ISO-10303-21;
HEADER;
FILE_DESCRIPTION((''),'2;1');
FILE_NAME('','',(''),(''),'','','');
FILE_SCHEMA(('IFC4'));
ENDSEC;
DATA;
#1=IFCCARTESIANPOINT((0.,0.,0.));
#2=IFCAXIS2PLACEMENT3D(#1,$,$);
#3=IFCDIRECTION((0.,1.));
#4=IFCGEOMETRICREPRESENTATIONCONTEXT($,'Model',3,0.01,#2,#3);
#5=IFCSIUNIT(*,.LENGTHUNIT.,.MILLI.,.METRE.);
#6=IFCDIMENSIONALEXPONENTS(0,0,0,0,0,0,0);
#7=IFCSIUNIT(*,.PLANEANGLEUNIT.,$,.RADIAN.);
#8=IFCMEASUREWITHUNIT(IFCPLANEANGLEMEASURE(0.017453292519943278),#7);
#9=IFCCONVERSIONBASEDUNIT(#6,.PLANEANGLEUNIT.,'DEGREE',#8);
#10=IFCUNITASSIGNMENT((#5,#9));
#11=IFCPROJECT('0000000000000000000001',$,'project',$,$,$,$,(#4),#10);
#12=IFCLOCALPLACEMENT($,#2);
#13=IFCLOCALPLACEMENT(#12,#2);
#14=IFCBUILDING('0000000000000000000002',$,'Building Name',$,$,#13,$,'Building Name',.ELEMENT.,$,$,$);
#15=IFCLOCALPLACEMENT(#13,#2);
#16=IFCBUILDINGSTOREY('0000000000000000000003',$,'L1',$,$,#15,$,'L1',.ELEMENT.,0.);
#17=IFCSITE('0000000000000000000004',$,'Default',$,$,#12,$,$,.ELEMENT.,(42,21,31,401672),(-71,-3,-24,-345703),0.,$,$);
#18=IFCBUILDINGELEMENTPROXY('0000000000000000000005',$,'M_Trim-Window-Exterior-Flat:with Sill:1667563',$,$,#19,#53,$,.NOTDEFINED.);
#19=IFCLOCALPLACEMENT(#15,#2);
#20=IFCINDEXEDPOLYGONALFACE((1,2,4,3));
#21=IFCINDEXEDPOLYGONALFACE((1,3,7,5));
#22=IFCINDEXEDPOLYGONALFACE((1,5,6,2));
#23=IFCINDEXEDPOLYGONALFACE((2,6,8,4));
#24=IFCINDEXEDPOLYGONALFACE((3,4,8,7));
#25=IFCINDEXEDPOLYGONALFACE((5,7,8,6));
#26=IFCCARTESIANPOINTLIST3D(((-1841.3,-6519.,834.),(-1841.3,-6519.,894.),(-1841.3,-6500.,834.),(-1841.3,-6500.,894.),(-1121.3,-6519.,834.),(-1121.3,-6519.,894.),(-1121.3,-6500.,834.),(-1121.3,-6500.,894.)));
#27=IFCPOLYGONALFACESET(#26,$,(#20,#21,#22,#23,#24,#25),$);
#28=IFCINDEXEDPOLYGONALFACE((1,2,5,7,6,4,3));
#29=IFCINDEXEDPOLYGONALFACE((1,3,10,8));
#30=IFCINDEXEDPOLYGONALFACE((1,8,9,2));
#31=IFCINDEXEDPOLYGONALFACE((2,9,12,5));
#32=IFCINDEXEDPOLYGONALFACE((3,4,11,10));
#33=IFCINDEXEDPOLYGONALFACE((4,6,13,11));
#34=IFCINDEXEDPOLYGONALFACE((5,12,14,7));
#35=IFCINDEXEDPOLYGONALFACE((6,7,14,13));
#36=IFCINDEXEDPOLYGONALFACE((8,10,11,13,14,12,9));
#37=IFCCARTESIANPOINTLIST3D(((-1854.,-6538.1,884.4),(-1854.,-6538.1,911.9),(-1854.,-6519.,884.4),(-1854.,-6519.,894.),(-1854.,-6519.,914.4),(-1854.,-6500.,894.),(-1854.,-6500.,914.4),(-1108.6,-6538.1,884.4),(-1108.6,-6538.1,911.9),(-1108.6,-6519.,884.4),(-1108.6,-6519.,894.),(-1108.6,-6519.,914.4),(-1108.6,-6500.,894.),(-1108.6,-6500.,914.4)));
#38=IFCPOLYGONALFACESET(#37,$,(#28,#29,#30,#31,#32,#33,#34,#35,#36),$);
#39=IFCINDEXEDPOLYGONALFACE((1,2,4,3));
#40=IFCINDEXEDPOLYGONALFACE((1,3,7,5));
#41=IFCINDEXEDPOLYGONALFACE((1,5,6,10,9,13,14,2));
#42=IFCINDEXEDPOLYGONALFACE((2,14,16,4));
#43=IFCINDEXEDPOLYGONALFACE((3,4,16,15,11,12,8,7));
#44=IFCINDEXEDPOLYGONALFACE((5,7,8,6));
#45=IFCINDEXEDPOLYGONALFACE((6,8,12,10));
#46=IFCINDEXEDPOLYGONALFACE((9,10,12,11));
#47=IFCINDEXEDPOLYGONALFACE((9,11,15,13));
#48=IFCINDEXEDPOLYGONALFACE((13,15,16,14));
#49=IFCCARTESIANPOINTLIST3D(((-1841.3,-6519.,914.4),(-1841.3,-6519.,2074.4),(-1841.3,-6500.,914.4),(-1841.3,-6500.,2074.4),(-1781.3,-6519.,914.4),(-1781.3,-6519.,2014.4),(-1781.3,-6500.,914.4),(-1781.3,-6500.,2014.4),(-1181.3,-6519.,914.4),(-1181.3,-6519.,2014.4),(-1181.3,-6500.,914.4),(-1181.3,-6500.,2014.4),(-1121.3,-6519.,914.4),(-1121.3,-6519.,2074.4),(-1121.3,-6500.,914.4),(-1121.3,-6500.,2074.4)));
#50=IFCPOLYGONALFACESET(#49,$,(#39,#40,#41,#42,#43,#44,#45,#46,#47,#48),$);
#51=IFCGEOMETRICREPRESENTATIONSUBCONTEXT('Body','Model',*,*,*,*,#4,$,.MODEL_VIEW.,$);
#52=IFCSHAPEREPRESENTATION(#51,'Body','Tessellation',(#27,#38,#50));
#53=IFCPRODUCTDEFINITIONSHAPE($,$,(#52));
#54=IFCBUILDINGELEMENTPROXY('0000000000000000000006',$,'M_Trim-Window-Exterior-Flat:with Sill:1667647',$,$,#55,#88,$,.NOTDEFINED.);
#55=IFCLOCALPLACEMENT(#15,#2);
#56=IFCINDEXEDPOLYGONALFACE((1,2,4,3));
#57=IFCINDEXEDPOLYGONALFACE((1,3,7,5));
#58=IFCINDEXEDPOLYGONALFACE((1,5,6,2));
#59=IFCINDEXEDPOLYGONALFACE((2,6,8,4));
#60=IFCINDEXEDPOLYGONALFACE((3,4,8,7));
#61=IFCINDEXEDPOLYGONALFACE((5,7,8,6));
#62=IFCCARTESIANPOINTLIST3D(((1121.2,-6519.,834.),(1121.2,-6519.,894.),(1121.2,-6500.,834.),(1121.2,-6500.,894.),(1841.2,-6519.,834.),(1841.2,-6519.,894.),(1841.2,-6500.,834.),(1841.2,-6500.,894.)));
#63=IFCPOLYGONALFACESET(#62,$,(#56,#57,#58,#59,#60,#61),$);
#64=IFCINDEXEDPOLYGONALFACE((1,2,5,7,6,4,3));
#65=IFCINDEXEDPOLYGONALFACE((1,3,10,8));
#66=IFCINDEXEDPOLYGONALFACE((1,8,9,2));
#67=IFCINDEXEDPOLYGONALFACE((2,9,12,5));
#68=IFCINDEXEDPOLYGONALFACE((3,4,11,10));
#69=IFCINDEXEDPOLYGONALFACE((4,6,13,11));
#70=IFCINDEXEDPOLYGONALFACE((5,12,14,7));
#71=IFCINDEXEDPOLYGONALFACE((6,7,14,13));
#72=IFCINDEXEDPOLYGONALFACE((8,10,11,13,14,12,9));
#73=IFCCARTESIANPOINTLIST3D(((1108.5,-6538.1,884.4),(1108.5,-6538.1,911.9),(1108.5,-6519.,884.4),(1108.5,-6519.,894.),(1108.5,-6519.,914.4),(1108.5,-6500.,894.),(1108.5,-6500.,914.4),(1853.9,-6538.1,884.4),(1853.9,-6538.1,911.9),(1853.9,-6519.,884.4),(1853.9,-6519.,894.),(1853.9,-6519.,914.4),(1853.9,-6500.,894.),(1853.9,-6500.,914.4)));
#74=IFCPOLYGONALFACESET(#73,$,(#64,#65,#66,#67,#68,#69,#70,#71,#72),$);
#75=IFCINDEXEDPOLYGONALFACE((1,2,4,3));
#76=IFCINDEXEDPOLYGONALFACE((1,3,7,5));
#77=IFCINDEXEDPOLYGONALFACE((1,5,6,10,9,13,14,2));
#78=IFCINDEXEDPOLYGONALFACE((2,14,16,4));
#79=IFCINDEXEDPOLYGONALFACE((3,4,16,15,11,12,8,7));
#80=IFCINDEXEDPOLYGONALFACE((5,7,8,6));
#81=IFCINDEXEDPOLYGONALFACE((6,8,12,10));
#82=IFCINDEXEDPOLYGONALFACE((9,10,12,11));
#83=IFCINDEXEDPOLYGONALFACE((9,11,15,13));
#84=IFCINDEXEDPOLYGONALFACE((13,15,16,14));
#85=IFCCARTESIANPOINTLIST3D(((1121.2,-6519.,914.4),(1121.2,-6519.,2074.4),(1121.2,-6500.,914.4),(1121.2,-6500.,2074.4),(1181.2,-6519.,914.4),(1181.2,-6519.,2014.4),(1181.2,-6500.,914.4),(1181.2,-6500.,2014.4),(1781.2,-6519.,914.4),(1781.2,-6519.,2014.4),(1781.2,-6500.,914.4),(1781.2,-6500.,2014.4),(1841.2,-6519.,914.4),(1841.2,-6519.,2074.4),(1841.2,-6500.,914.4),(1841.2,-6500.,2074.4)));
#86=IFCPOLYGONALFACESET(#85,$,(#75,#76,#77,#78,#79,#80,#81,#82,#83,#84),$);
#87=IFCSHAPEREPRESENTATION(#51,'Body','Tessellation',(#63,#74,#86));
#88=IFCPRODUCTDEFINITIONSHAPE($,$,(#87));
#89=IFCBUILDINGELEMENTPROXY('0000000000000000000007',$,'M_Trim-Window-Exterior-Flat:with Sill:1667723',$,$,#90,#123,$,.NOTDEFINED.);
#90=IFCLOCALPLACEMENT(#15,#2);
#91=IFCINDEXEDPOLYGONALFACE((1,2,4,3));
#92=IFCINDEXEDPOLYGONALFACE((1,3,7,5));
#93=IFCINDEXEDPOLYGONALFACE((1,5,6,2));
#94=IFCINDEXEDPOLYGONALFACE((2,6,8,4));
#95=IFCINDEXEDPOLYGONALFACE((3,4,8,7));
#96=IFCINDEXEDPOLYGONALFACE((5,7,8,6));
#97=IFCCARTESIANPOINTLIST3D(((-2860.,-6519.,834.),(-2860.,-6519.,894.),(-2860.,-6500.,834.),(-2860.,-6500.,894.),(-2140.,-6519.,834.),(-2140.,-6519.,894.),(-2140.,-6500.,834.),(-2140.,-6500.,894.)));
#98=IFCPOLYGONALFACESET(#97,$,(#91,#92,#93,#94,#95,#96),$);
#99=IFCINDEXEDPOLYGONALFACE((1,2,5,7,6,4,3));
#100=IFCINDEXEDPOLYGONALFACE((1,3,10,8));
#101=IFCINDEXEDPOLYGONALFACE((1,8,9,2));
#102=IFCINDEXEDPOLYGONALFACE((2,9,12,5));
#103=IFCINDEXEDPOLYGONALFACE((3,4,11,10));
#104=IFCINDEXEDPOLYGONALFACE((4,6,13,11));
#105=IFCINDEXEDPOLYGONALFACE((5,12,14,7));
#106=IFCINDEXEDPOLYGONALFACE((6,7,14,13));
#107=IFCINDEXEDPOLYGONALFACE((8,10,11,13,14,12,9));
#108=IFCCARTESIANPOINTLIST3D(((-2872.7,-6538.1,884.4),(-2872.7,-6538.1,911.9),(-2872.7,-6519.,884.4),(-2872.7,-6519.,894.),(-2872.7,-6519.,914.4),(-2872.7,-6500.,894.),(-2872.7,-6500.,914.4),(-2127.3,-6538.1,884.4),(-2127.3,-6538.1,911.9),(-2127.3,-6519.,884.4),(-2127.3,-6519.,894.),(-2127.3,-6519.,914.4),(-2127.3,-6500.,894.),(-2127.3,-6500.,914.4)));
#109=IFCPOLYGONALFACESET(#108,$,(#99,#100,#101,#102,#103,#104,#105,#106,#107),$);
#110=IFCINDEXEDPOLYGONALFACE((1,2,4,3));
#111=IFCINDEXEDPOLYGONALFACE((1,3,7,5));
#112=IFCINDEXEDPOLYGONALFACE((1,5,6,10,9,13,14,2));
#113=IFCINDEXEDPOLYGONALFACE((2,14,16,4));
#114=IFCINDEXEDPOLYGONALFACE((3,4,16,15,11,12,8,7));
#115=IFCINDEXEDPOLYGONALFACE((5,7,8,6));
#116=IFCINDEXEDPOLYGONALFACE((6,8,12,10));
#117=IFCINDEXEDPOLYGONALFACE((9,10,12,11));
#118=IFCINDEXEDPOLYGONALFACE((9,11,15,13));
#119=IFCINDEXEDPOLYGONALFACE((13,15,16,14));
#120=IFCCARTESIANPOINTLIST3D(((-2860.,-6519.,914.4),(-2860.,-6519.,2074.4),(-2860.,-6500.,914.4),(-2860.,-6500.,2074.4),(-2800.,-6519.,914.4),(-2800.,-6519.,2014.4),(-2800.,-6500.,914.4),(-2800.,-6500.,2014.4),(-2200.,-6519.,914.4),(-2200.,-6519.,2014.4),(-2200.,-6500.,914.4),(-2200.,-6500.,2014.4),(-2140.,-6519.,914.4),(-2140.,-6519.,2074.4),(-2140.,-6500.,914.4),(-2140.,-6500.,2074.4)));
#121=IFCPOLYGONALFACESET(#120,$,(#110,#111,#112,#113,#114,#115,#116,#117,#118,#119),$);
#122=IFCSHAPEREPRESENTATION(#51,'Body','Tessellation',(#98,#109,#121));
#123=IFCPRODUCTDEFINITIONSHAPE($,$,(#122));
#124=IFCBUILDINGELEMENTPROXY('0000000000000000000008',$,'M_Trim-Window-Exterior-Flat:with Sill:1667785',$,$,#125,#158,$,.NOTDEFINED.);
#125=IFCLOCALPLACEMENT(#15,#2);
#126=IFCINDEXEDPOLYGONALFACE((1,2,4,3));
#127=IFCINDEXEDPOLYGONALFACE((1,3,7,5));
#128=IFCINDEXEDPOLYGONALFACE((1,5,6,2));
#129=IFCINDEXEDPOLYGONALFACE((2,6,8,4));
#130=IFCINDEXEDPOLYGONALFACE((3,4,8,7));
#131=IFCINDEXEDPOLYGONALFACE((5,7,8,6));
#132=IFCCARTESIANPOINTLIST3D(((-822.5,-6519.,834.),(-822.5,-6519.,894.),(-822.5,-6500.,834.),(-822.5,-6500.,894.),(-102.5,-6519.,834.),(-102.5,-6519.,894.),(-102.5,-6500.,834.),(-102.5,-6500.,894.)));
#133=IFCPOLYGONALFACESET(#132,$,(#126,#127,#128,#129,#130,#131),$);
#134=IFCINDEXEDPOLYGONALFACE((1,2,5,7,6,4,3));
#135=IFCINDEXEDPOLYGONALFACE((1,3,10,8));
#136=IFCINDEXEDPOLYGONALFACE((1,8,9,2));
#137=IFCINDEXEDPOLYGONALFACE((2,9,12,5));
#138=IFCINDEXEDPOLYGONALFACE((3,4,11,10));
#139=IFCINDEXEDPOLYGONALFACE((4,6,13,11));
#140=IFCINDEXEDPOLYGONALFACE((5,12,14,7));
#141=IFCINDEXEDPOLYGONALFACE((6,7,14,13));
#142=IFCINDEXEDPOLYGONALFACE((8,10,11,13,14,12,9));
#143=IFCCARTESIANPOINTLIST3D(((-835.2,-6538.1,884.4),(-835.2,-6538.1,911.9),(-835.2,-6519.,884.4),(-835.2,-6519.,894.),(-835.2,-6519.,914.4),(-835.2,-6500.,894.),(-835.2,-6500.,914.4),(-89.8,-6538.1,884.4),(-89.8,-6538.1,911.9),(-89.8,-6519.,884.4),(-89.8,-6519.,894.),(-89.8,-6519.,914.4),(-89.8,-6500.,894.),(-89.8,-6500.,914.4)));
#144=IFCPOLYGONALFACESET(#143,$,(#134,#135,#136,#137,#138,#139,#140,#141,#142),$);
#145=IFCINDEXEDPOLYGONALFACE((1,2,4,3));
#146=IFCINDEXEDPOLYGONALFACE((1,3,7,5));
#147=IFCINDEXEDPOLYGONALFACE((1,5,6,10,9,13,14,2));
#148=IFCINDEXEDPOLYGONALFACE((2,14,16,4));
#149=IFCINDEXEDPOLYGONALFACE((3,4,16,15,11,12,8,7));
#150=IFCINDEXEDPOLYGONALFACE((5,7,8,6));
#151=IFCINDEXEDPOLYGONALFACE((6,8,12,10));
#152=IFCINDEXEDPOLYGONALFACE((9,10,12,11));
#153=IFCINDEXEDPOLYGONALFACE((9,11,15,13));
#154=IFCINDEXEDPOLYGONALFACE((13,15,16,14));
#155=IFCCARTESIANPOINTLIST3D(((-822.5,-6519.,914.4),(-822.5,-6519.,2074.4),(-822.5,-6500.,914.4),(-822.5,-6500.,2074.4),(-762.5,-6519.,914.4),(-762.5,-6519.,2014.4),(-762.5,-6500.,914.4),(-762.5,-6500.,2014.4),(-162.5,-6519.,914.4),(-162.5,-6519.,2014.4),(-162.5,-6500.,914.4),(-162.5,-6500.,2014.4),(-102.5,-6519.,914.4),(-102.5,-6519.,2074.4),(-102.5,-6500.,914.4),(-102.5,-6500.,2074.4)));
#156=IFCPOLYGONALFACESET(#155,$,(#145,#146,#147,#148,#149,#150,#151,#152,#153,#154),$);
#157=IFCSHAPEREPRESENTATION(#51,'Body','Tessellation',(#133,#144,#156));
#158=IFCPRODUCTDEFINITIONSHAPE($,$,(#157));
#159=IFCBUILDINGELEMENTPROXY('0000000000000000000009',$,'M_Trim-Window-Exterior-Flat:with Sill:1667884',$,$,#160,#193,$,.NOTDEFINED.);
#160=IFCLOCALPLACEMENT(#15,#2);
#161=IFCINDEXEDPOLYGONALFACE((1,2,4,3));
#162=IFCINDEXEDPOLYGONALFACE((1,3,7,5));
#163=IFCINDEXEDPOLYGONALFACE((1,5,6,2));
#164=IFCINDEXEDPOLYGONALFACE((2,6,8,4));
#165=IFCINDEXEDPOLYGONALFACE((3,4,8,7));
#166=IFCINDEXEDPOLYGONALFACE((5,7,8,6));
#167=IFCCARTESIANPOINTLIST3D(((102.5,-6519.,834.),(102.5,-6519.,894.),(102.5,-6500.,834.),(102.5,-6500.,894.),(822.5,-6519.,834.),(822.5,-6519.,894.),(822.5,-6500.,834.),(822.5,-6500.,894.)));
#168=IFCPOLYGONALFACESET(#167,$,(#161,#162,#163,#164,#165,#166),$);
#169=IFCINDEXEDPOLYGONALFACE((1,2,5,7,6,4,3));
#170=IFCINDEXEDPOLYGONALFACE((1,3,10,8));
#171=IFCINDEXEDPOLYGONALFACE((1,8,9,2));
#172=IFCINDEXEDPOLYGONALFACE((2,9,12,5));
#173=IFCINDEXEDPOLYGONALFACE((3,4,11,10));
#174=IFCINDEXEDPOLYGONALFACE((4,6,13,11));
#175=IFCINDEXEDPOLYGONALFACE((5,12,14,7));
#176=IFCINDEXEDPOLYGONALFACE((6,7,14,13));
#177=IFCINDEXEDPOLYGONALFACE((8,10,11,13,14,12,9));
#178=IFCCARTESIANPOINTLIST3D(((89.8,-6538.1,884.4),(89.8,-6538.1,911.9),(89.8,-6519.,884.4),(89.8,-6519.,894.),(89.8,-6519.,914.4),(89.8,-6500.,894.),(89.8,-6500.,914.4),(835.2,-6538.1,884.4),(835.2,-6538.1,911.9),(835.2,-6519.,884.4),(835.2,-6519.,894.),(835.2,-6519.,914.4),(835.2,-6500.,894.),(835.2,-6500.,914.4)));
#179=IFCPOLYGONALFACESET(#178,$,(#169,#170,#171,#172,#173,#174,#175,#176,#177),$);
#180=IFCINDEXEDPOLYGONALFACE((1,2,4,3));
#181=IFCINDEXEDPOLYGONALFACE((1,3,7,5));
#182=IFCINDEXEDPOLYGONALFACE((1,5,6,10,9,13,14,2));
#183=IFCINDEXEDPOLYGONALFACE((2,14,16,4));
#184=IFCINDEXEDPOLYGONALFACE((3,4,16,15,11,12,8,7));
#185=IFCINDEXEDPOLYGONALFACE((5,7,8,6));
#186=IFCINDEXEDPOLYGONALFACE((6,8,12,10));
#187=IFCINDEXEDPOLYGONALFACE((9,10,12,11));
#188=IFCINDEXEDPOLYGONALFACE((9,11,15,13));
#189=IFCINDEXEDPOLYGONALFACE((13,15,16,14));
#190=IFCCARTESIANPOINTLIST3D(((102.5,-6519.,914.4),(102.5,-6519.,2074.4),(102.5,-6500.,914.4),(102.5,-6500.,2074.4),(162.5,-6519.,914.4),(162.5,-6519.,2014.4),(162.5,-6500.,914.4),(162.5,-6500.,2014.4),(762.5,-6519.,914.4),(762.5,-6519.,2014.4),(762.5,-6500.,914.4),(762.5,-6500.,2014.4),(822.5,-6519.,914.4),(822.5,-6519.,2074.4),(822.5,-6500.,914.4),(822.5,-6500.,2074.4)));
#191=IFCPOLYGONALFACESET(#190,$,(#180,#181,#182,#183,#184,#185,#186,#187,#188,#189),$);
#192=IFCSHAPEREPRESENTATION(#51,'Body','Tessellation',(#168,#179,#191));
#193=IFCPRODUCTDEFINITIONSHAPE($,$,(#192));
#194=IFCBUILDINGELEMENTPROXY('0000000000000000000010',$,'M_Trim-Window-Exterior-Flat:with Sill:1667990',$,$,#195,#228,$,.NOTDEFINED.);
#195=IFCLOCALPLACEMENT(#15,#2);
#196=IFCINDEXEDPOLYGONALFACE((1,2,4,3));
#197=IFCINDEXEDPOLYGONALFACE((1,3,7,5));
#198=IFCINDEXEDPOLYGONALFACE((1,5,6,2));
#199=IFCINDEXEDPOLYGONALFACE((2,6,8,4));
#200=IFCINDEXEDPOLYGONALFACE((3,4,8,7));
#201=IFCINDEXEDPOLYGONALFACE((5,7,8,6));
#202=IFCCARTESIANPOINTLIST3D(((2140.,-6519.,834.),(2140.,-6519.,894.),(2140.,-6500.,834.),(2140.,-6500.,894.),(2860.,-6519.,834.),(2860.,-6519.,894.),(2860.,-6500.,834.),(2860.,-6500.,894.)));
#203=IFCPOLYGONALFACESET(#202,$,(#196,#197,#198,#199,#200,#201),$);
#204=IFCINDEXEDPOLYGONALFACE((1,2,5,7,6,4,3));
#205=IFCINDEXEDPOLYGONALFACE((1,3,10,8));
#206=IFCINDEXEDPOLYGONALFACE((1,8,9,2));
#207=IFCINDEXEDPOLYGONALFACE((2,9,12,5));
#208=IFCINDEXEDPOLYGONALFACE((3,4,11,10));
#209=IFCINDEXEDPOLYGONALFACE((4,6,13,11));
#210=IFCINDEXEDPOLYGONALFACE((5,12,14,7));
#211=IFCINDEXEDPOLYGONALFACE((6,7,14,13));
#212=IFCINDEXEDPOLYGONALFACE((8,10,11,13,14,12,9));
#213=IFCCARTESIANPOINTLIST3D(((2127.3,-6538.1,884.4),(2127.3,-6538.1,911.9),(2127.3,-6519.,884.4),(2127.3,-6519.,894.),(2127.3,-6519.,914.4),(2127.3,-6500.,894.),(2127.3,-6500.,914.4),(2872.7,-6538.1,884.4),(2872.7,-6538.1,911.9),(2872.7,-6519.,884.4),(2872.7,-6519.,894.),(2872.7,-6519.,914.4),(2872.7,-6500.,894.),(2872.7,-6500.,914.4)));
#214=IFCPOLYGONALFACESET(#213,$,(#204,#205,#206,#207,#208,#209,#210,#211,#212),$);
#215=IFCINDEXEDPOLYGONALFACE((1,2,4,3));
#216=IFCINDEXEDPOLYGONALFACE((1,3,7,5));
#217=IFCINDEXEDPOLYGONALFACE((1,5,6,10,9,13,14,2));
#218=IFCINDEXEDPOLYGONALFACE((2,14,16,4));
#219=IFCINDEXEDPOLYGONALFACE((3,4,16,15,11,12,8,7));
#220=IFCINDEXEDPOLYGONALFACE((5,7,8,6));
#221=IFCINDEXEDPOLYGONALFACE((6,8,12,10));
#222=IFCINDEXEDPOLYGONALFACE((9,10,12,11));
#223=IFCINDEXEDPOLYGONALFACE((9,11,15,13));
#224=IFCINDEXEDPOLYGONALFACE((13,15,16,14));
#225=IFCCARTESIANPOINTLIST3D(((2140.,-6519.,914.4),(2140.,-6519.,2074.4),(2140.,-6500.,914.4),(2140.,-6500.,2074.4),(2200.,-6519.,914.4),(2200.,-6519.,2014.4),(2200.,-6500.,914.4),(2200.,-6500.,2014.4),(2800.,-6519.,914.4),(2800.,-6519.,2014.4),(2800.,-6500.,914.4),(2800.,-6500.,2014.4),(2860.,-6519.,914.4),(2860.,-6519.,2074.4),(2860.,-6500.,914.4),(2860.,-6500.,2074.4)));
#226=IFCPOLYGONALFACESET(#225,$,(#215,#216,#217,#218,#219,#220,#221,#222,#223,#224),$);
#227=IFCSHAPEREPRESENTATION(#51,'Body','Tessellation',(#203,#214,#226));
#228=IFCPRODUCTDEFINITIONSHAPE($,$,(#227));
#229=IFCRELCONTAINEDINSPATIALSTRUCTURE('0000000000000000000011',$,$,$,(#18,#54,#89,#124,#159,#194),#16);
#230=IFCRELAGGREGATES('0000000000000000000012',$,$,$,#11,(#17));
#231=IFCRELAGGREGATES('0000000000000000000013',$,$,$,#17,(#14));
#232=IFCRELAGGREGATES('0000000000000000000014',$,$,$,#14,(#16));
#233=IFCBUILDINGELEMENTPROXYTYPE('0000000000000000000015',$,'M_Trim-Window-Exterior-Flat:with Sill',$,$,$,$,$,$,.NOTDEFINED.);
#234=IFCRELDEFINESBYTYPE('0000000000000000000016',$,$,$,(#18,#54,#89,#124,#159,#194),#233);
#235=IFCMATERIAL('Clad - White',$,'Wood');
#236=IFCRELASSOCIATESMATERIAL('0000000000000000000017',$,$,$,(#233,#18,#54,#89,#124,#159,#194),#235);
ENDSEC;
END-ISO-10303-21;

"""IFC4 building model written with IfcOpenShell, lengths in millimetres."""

from ifc_helpers import new_model, entity, si_unit, converted_unit, direction, frame, origin, place, context, subcontext, project, spatial, indexed_curve, outline, extrude, source, transform, mapped, material, type_object, type_shapes, element, save


model = new_model("IFC4")

# Units and contexts
model_context = context("Model", 3, precision=0.01, world=origin(), true_north=direction((0.0, 1.0)))
body_context = subcontext(model_context, "Body", "Model", "MODEL_VIEW")
ifc_project = project(units=[si_unit("LENGTHUNIT", "METRE", prefix="MILLI"), converted_unit("PLANEANGLEUNIT", "DEGREE", entity("IfcPlaneAngleMeasure", 0.017453292519943278), si_unit("PLANEANGLEUNIT", "RADIAN"), dimensions=[0, 0, 0, 0, 0, 0, 0])], contexts=[model_context])

# Site, building, storey
site_placement = place(None, origin())
site = spatial("IfcSite", under=ifc_project, at=site_placement, Name="Default", CompositionType="ELEMENT", RefLatitude=(42, 21, 31, 401672), RefLongitude=(-71, -3, -24, -345703), RefElevation=0.0)
building_placement = place(site_placement, origin())
building = spatial("IfcBuilding", under=site, at=building_placement, Name="Building Name", LongName="Building Name", CompositionType="ELEMENT")
storey_placement = place(building_placement, origin())
storey = spatial("IfcBuildingStorey", under=building, at=storey_placement, Name="L1", LongName="L1", CompositionType="ELEMENT", Elevation=0.0)

# Building element proxies
ifc_material_1 = material(Name="Clad - White", Category="Wood")
building_element_proxy_type_1 = type_object("IfcBuildingElementProxyType", Name="M_Trim-Window-Exterior-Flat:with Sill", PredefinedType="NOTDEFINED", material=ifc_material_1)
shared_shape_1 = source(origin(), body_context, "Body", "SweptSolid", [
    extrude(outline(indexed_curve([(-360.0, -30.0), (360.0, -30.0), (360.0, 30.0), (-360.0, 30.0), (-360.0, -30.0)], self_intersect=False)), frame((0.0, -1150.4, 0.0), z_axis=(0.0, 0.0, 1.0), x_axis=(-1.0, 0.0, 0.0)), (0.0, 0.0, 1.0), 19.0),
    extrude(outline(indexed_curve([(-19.0, -15.2), (0.0, -15.2), (0.0, -5.7), (19.0, -5.7), (19.0, 14.8), (0.0, 14.8), (-19.0, 12.3), (-19.0, -15.2)], self_intersect=False)), frame((-372.7, -1114.8, 19.0), z_axis=(1.0, 0.0, 0.0), x_axis=(0.0, 0.0, -1.0)), (0.0, 0.0, 1.0), 745.4),
    extrude(outline(indexed_curve([(-595.0, -360.0), (565.0, -360.0), (565.0, -300.0), (-535.0, -300.0), (-535.0, 300.0), (565.0, 300.0), (565.0, 360.0), (-595.0, 360.0), (-595.0, -360.0)], self_intersect=False)), frame((0.0, -535.0, 0.0), z_axis=(0.0, 0.0, 1.0), x_axis=(0.0, -1.0, 0.0)), (0.0, 0.0, 1.0), 19.0),
])
type_shapes(building_element_proxy_type_1, [shared_shape_1])
for number, where, z_axis, x_axis, name in (
    (1, (-1481.3, -6500.0, 2014.4), (0.0, -1.0, 0.0), (1.0, 0.0, 0.0), "M_Trim-Window-Exterior-Flat:with Sill:1667563"),
    (2, (1481.2, -6500.0, 2014.4), (0.0, -1.0, 0.0), (1.0, 0.0, 0.0), "M_Trim-Window-Exterior-Flat:with Sill:1667647"),
    (3, (-2500.0, -6500.0, 2014.4), (0.0, -1.0, 0.0), (1.0, 0.0, 0.0), "M_Trim-Window-Exterior-Flat:with Sill:1667723"),
    (4, (-462.5, -6500.0, 2014.4), (0.0, -1.0, 0.0), (1.0, 0.0, 0.0), "M_Trim-Window-Exterior-Flat:with Sill:1667785"),
    (5, (462.5, -6500.0, 2014.4), (0.0, -1.0, 0.0), (1.0, 0.0, 0.0), "M_Trim-Window-Exterior-Flat:with Sill:1667884"),
    (6, (2500.0, -6500.0, 2014.4), (0.0, -1.0, 0.0), (1.0, 0.0, 0.0), "M_Trim-Window-Exterior-Flat:with Sill:1667990"),
):
    element("IfcBuildingElementProxy", number, at=place(storey_placement, frame(where, z_axis=z_axis, x_axis=x_axis)), inside=storey, type_object=building_element_proxy_type_1, material=ifc_material_1, Name=name, PredefinedType="NOTDEFINED", context=body_context, shape_type="MappedRepresentation", body=[
        mapped(shared_shape_1, transform((0.0, 0.0, 0.0), scale=1.0)),
    ])

save(model, "model.ifc")
